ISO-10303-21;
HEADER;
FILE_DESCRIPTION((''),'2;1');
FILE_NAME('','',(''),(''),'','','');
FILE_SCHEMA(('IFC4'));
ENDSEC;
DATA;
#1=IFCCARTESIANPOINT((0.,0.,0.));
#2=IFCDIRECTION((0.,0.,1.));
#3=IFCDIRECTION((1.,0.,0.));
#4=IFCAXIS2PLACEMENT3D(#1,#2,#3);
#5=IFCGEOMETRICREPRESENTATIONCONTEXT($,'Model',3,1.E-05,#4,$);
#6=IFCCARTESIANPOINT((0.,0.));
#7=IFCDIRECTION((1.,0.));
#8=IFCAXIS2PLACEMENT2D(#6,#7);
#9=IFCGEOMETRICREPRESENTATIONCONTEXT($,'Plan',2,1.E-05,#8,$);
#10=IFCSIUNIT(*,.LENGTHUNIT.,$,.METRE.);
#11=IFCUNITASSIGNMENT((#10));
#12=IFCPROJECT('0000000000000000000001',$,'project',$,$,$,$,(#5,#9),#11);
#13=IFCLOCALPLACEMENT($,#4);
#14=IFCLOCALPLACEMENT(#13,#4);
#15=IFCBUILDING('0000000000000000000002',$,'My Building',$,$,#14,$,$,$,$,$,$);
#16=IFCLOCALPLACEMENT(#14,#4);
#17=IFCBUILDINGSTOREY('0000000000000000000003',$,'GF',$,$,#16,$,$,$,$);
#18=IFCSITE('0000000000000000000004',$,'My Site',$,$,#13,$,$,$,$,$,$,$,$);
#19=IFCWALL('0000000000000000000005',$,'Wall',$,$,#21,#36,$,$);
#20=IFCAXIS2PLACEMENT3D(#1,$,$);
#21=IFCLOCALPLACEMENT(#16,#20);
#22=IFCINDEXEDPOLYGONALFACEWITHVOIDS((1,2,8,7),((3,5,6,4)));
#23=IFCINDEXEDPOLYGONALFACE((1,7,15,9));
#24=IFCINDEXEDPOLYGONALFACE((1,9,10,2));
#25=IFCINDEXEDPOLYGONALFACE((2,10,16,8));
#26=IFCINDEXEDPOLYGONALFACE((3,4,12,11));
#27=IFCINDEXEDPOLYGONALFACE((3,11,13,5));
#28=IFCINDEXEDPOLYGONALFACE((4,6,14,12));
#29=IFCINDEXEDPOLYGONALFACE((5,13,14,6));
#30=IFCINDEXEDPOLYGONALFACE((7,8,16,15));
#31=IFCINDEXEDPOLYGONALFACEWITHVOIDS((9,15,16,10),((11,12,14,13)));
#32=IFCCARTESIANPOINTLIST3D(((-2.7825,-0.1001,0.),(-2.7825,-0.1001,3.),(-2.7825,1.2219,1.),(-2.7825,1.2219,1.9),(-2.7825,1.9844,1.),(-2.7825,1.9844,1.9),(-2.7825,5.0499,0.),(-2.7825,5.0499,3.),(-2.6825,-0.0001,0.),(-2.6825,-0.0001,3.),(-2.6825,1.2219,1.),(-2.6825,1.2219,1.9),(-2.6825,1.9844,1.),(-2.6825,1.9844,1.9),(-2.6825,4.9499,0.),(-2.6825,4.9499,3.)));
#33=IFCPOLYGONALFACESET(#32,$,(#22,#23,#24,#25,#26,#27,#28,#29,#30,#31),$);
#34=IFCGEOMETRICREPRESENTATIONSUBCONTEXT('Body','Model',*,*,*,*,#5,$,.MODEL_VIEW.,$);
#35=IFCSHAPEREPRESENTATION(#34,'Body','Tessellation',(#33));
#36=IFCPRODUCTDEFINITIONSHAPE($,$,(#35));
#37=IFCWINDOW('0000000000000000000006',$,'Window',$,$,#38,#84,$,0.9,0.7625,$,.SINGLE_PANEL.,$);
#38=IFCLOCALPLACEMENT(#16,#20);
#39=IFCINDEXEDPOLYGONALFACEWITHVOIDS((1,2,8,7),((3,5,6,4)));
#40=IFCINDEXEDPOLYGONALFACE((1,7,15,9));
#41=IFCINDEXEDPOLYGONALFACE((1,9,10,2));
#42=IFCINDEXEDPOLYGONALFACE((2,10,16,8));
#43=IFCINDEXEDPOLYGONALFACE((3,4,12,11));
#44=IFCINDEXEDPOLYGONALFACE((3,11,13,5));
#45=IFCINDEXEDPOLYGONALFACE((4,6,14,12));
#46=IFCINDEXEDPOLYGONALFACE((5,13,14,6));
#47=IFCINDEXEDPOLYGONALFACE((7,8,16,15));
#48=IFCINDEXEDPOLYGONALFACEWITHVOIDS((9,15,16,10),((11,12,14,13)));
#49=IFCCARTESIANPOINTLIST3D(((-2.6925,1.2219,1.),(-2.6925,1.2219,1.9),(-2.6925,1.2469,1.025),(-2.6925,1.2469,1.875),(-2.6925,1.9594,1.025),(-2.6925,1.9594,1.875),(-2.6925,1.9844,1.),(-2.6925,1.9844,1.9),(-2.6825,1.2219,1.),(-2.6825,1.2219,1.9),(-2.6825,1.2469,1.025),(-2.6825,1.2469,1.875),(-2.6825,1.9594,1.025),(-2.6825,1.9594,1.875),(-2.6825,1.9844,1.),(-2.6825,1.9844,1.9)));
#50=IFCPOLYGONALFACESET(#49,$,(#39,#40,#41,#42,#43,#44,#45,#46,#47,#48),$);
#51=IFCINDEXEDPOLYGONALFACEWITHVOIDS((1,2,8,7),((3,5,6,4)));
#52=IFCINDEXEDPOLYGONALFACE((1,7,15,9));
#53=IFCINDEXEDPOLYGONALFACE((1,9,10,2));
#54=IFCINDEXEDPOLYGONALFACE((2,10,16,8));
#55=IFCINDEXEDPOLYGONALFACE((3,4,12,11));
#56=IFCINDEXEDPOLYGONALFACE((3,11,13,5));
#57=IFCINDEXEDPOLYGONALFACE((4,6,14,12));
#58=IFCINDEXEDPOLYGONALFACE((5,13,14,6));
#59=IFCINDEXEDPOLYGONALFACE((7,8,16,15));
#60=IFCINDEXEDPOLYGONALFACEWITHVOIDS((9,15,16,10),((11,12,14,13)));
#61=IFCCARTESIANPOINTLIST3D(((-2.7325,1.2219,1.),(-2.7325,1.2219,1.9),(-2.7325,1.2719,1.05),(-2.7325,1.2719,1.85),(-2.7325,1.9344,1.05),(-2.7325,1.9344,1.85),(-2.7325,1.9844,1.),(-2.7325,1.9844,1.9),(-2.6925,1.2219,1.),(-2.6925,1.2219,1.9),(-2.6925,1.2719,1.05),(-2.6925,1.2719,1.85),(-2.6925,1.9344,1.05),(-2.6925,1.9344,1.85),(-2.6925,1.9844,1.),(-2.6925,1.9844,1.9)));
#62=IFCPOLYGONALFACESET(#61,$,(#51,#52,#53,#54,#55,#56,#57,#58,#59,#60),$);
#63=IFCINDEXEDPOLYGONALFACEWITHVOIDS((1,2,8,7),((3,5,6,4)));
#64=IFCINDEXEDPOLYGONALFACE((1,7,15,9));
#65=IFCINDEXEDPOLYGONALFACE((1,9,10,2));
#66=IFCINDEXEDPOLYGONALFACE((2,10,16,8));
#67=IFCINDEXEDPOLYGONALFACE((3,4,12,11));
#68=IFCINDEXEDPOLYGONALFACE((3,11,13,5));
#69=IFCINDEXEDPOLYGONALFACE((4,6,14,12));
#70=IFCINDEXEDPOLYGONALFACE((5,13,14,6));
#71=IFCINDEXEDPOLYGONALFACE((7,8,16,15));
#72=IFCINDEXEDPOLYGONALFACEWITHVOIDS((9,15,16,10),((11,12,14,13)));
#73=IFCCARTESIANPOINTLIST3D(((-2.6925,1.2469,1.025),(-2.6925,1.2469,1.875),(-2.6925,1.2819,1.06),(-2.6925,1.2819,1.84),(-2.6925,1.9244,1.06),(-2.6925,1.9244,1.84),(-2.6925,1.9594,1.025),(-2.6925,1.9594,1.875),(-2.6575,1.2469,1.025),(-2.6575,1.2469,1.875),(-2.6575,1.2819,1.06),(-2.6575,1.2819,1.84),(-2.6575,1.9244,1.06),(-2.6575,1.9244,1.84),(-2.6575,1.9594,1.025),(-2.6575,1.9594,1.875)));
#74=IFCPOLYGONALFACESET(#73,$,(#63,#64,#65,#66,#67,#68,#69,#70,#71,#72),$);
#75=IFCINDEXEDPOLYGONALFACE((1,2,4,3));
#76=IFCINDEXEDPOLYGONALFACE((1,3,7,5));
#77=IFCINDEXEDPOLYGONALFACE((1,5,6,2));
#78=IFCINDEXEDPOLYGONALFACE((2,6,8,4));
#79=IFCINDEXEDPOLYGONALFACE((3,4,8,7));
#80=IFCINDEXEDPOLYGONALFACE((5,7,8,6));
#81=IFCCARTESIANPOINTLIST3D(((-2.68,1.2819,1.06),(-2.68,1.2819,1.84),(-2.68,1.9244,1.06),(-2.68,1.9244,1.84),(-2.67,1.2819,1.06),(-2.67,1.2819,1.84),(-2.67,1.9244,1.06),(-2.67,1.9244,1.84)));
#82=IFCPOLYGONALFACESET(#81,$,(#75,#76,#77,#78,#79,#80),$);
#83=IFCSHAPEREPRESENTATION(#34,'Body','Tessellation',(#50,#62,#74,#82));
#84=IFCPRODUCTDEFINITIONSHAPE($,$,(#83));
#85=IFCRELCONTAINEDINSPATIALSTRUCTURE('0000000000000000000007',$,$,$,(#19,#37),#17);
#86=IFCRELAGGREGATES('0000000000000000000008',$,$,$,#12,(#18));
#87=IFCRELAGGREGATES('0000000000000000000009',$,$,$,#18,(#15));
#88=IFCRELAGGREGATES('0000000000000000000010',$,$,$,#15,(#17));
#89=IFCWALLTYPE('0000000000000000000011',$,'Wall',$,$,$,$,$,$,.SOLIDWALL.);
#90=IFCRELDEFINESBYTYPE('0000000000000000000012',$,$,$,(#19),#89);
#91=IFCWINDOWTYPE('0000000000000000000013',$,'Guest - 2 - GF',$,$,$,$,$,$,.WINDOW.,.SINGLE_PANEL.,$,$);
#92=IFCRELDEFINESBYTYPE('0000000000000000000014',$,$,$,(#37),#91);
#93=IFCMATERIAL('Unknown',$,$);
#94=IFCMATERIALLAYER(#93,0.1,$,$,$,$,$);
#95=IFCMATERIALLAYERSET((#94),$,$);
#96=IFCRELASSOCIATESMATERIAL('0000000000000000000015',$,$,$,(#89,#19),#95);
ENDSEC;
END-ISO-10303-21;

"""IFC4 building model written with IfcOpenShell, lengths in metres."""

from ifc_helpers import new_model, entity, si_unit, frame, origin_with_axes, origin_2d_with_axis, place, context, subcontext, project, spatial, line, indexed_curve, outline, extrude, shape, source, transform, mapped, material, layer, layer_set, layer_usage, type_object, type_shapes, element, fill, save


model = new_model("IFC4")

# Units and contexts
model_context = context("Model", 3, precision=1e-05, world=origin_with_axes())
plan_context = context("Plan", 2, precision=1e-05, world=origin_2d_with_axis())
body_context_1 = subcontext(model_context, "Body", "Model", "MODEL_VIEW")
body_context_2 = subcontext(plan_context, "Body", "Plan", "PLAN_VIEW")
ifc_project = project(units=[si_unit("LENGTHUNIT", "METRE")], contexts=[model_context, plan_context])

# Site, building, storey
site_placement = place(None, origin_with_axes())
site = spatial("IfcSite", under=ifc_project, at=site_placement, Name="My Site")
building_placement = place(site_placement, origin_with_axes())
building = spatial("IfcBuilding", under=site, at=building_placement, Name="My Building")
storey_placement = place(building_placement, origin_with_axes())
storey = spatial("IfcBuildingStorey", under=building, at=storey_placement, Name="GF")

# Shared definitions
ifc_material_1 = material(Name="Unknown")

# Shared definitions
ifc_layer_1 = layer(ifc_material_1, 0.1)
ifc_layer_set_1 = layer_set([ifc_layer_1])
wall_type = type_object("IfcWallType", Name="Wall", PredefinedType="SOLIDWALL", material=ifc_layer_set_1)

# Wall, opening, window
ifc_layer_usage_1 = layer_usage(ifc_layer_set_1, "AXIS2", "POSITIVE", 0.0)
wall_1_placement = place(storey_placement, frame((-2.7825, 5.0499, 0.0), z_axis=(0.0, 0.0, 1.0), x_axis=(0.0, -1.0, 0.0)))
wall_1 = element("IfcWall", 1, at=wall_1_placement, inside=storey, type_object=wall_type, material=ifc_layer_usage_1, Name="Wall", context=body_context_1, shape_type="SweptSolid", body=[
    extrude(outline(indexed_curve([(0.0, 0.0), (0.1, 0.1), (5.05, 0.1), (5.15, 0.0)], segments=[line(1, 2, 3, 4, 1)])), origin_with_axes(), (0.0, 0.0, 1.0), 3.0),
])
shared_shape_1 = source(origin_with_axes(), body_context_1, "Body", "SweptSolid", [
    extrude(outline(indexed_curve([(0.0, 0.0), (0.7625, 0.0), (0.7625, 0.9), (0.0, 0.9)], segments=[line(1, 2, 3, 4, 1)])), frame((0.0, -0.6, 0.0), z_axis=(0.0, -1.0, 0.0), x_axis=(1.0, 0.0, 0.0)), (0.0, 0.0, -1.0), 1.2),
])
opening_1_placement = place(wall_1_placement, frame((3.0656, 0.0, 1.0), z_axis=(0.0, 0.0, 1.0), x_axis=(1.0, 0.0, 0.0)))
opening_1 = element("IfcOpeningElement", 2, at=opening_1_placement, cuts=wall_1, PredefinedType="OPENING", context=body_context_1, shape_type="MappedRepresentation", body=[
    mapped(shared_shape_1, transform((0.0, 0.0, 0.0), x_axis=(1.0, 0.0, 0.0), y_axis=(0.0, 1.0, 0.0), z_axis=(0.0, 0.0, 1.0), scale=1.0)),
])
window_type_1 = type_object("IfcWindowType", Name="Guest - 2 - GF", PartitioningType="SINGLE_PANEL", PredefinedType="WINDOW")
shared_shape_2 = source(origin_with_axes(), body_context_1, "Body", "SweptSolid", [
    extrude(outline(indexed_curve([(0.0, 0.0), (0.7625, 0.0), (0.7625, 0.9), (0.0, 0.9)], segments=[line(1, 2, 3, 4, 1)]), holes=[indexed_curve([(0.025, 0.025), (0.7375, 0.025), (0.7375, 0.875), (0.025, 0.875)], segments=[line(1, 2, 3, 4, 1)])]), frame((0.0, 0.09, 0.0), z_axis=(0.0, -1.0, 0.0), x_axis=(1.0, 0.0, 0.0)), (0.0, 0.0, -1.0), 0.01),
    extrude(outline(indexed_curve([(0.0, 0.0), (0.7625, 0.0), (0.7625, 0.9), (0.0, 0.9)], segments=[line(1, 2, 3, 4, 1)]), holes=[indexed_curve([(0.05, 0.05), (0.7125, 0.05), (0.7125, 0.85), (0.05, 0.85)], segments=[line(1, 2, 3, 4, 1)])]), frame((0.0, 0.05, 0.0), z_axis=(0.0, -1.0, 0.0), x_axis=(1.0, 0.0, 0.0)), (0.0, 0.0, -1.0), 0.04),
    extrude(outline(indexed_curve([(0.0, 0.0), (0.7125, 0.0), (0.7125, 0.85), (0.0, 0.85)], segments=[line(1, 2, 3, 4, 1)]), holes=[indexed_curve([(0.035, 0.035), (0.6775, 0.035), (0.6775, 0.815), (0.035, 0.815)], segments=[line(1, 2, 3, 4, 1)])]), frame((0.025, 0.09, 0.025), z_axis=(0.0, -1.0, 0.0), x_axis=(1.0, 0.0, 0.0)), (0.0, 0.0, -1.0), 0.035),
    extrude(outline(indexed_curve([(0.035, 0.035), (0.6775, 0.035), (0.6775, 0.815), (0.035, 0.815)], segments=[line(1, 2, 3, 4, 1)])), frame((0.025, 0.1025, 0.025), z_axis=(0.0, -1.0, 0.0), x_axis=(1.0, 0.0, 0.0)), (0.0, 0.0, -1.0), 0.01),
])
shared_shape_3 = source(origin_with_axes(), body_context_2, "Body", "Curve2D", [
    entity("IfcIndexedPolyCurve", entity("IfcCartesianPointList2D", [[0.05, 0.05], [0.7125, 0.05]])),
    entity("IfcIndexedPolyCurve", entity("IfcCartesianPointList2D", [[0.0, 0.1], [0.025, 0.1], [0.025, 0.09], [0.05, 0.09], [0.05, 0.05], [0.0, 0.05]]), [entity("IfcLineIndex", [1, 2, 3, 4, 5, 6, 1])]),
    entity("IfcIndexedPolyCurve", entity("IfcCartesianPointList2D", [[0.7625, 0.1], [0.7375, 0.1], [0.7375, 0.09], [0.7125, 0.09], [0.7125, 0.05], [0.7625, 0.05]]), [entity("IfcLineIndex", [1, 2, 3, 4, 5, 6, 1])]),
    entity("IfcIndexedPolyCurve", entity("IfcCartesianPointList2D", [[0.025, 0.09], [0.06, 0.09], [0.06, 0.125], [0.025, 0.125]]), [entity("IfcLineIndex", [1, 2, 3, 4, 1])]),
    entity("IfcIndexedPolyCurve", entity("IfcCartesianPointList2D", [[0.7375, 0.09], [0.7025, 0.09], [0.7025, 0.125], [0.7375, 0.125]]), [entity("IfcLineIndex", [1, 2, 3, 4, 1])]),
    entity("IfcIndexedPolyCurve", entity("IfcCartesianPointList2D", [[0.06, 0.09], [0.7025, 0.09]])),
    entity("IfcIndexedPolyCurve", entity("IfcCartesianPointList2D", [[0.06, 0.125], [0.7025, 0.125]])),
    entity("IfcIndexedPolyCurve", entity("IfcCartesianPointList2D", [[0.06, 0.1075], [0.7025, 0.1075]])),
])
type_shapes(window_type_1, [shared_shape_2, shared_shape_3])
window_1_placement = place(opening_1_placement, frame((0.0, 0.0, 0.0), z_axis=(0.0, 0.0, 1.0), x_axis=(1.0, 0.0, 0.0)))
window_1 = element("IfcWindow", 3, at=window_1_placement, inside=storey, type_object=window_type_1, Name="Window", OverallHeight=0.9, OverallWidth=0.7625, PartitioningType="SINGLE_PANEL", shapes=[
    shape(body_context_1, "Body", "MappedRepresentation", [mapped(shared_shape_2, transform((0.0, 0.0, 0.0), x_axis=(1.0, 0.0, 0.0), y_axis=(0.0, 1.0, 0.0), z_axis=(0.0, 0.0, 1.0), scale=1.0))]),
    shape(body_context_2, "Body", "MappedRepresentation", [mapped(shared_shape_3, transform((0.0, 0.0, 0.0), x_axis=(1.0, 0.0, 0.0), y_axis=(0.0, 1.0, 0.0), z_axis=(0.0, 0.0, 1.0), scale=1.0))]),
])
fill(opening_1, window_1)

save(model, "model.ifc")
